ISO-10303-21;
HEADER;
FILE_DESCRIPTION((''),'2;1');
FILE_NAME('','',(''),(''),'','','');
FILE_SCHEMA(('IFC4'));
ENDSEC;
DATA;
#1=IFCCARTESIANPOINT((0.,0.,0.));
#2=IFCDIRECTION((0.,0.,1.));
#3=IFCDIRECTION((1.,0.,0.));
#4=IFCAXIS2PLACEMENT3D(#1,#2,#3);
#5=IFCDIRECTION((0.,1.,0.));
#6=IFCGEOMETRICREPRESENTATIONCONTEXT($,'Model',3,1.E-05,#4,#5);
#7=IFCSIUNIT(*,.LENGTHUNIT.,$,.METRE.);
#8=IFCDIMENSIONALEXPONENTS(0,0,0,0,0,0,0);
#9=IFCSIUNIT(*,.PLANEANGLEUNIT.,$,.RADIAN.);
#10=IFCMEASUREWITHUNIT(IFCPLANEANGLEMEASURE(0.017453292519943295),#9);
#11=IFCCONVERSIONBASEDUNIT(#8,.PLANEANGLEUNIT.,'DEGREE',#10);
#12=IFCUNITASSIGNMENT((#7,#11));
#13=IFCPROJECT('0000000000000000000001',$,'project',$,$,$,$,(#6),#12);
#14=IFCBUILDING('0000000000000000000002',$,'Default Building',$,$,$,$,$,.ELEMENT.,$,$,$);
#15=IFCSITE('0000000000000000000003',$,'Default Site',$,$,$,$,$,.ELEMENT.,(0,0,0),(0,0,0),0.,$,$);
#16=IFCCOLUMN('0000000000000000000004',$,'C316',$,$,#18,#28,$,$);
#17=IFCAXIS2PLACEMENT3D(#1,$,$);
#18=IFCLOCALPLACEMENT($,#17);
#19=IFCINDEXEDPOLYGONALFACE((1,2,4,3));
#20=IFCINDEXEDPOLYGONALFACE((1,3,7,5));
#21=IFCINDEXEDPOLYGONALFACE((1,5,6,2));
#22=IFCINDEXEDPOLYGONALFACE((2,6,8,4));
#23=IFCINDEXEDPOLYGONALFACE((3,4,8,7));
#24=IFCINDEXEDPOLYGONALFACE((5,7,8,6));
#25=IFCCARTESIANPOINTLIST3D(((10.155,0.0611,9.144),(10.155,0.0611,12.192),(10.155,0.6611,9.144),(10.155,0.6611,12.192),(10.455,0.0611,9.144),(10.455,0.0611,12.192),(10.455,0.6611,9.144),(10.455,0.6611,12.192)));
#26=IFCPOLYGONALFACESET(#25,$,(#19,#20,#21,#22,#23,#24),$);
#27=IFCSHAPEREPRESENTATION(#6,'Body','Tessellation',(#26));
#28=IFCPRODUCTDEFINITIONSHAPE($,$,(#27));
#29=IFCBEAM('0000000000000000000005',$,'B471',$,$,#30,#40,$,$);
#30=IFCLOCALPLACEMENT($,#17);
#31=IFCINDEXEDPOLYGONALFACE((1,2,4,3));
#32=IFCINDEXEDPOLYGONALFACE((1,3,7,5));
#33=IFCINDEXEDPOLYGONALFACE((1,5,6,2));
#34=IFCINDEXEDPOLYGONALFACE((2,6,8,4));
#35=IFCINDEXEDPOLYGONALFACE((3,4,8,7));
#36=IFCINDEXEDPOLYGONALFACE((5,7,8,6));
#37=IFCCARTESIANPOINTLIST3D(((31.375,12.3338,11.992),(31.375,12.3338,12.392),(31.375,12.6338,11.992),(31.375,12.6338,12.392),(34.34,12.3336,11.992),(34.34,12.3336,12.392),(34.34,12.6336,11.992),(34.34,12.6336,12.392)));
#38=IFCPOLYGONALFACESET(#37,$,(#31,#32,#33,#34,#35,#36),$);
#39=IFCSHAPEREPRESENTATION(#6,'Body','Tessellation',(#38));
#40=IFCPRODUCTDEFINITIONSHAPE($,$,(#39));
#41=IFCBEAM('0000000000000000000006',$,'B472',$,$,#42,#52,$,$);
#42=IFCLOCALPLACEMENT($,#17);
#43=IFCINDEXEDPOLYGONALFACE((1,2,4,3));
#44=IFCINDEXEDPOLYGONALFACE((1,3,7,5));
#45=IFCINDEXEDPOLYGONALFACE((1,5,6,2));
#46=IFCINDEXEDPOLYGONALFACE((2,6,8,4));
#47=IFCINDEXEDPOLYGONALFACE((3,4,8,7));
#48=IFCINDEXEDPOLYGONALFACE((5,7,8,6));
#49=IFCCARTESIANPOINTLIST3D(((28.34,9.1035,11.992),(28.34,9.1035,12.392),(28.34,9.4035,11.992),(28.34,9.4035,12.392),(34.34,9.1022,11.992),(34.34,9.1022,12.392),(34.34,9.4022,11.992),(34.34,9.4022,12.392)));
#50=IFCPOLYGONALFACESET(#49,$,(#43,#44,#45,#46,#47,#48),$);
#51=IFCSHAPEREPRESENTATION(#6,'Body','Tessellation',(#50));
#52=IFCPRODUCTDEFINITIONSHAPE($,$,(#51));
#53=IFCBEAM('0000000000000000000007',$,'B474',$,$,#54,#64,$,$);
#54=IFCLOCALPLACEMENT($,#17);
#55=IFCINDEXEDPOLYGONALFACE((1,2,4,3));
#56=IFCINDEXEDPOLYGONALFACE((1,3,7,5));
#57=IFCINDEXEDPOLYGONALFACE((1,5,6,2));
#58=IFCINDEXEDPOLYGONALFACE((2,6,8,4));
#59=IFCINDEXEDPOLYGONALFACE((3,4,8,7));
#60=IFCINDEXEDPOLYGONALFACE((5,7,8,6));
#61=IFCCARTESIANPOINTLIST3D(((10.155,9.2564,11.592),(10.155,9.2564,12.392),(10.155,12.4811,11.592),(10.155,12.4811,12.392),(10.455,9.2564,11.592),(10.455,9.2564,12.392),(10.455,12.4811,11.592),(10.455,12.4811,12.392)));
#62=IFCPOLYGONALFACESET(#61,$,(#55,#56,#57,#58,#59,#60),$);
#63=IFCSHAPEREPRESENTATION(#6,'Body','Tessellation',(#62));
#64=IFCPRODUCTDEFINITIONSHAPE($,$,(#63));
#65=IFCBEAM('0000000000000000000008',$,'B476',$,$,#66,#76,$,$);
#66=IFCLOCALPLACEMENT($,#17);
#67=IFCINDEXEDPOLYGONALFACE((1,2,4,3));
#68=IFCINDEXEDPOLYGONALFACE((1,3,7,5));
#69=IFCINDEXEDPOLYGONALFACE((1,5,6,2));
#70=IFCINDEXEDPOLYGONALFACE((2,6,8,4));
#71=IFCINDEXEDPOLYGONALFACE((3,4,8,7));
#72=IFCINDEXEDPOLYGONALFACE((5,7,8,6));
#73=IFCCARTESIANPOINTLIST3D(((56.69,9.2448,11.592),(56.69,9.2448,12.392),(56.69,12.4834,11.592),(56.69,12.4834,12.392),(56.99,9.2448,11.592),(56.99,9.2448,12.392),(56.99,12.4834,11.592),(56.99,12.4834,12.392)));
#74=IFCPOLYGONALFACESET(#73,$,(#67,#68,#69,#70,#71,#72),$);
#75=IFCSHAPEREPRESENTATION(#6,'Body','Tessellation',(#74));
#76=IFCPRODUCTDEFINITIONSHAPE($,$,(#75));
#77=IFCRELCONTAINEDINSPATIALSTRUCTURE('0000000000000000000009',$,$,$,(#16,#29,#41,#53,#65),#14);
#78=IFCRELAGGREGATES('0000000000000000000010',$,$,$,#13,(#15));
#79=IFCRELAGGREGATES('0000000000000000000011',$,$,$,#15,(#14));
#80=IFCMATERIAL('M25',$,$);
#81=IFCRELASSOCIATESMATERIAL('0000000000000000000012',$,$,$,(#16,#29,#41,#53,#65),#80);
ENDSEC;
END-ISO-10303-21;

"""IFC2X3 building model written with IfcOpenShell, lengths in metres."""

from ifc_helpers import new_model, entity, si_unit, converted_unit, direction, frame, frame_2d, origin_with_axes, place, context, project, spatial, rectangle, extrude, material, element, save


model = new_model("IFC2X3")

# Units and contexts
model_context = context("Model", 3, precision=1e-05, world=origin_with_axes(), true_north=direction((0.0, 1.0, 0.0)))
ifc_project = project(units=[si_unit("LENGTHUNIT", "METRE"), converted_unit("PLANEANGLEUNIT", "DEGREE", entity("IfcPlaneAngleMeasure", 0.017453292519943295), si_unit("PLANEANGLEUNIT", "RADIAN"), dimensions=[0, 0, 0, 0, 0, 0, 0])], contexts=[model_context])

# Site, building
site = spatial("IfcSite", under=ifc_project, Name="Default Site", CompositionType="ELEMENT", RefLatitude=(0, 0, 0), RefLongitude=(0, 0, 0), RefElevation=0.0)
building = spatial("IfcBuilding", under=site, Name="Default Building", CompositionType="ELEMENT")

# Column
ifc_material = material(Name="M25")
placement = place(None, origin_with_axes())
element("IfcColumn", 1, at=placement, inside=building, material=ifc_material, Name="C316", context=model_context, shape_type="SweptSolid", body=[
    extrude(rectangle(XDim=0.3, YDim=0.6, at=frame_2d((0.0, 0.0), x_axis=(1.0, 0.0, 0.0))), frame((10.305, 0.3611, 9.144), z_axis=(0.0, 0.0, 1.0), x_axis=(1.0, 0.0, 0.0)), (0.0, 0.0, 1.0), 3.048),
])

# Beams
element("IfcBeam", 2, at=placement, inside=building, material=ifc_material, Name="B471", context=model_context, shape_type="SweptSolid", body=[
    extrude(rectangle(XDim=0.3, YDim=0.4, at=frame_2d((0.0, 0.0), x_axis=(0.0, 1.0, 0.0))), frame((31.375, 12.4838, 12.192), z_axis=(1.0, -0.000067, 0.0), x_axis=(0.0, 0.0, -1.0)), (0.0, 0.0, 1.0), 2.965),
])
element("IfcBeam", 3, at=placement, inside=building, material=ifc_material, Name="B472", context=model_context, shape_type="SweptSolid", body=[
    extrude(rectangle(XDim=0.3, YDim=0.4, at=frame_2d((0.0, 0.0), x_axis=(0.0, 1.0, 0.0))), frame((28.34, 9.2535, 12.192), z_axis=(1.0, -0.000213, 0.0), x_axis=(0.0, 0.0, -1.0)), (0.0, 0.0, 1.0), 6.0),
])
element("IfcBeam", 4, at=placement, inside=building, material=ifc_material, Name="B474", context=model_context, shape_type="SweptSolid", body=[
    extrude(rectangle(XDim=0.3, YDim=0.8, at=frame_2d((0.0, 0.0), x_axis=(0.0, 1.0, 0.0))), frame((10.305, 12.4811, 11.992), z_axis=(0.0, -1.0, 0.0), x_axis=(0.0, 0.0, -1.0)), (0.0, 0.0, 1.0), 3.2247),
])
element("IfcBeam", 5, at=placement, inside=building, material=ifc_material, Name="B476", context=model_context, shape_type="SweptSolid", body=[
    extrude(rectangle(XDim=0.3, YDim=0.8, at=frame_2d((0.0, 0.0), x_axis=(0.0, 1.0, 0.0))), frame((56.84, 12.4834, 11.992), z_axis=(0.0, -1.0, 0.0), x_axis=(0.0, 0.0, -1.0)), (0.0, 0.0, 1.0), 3.2386),
])

save(model, "model.ifc")
